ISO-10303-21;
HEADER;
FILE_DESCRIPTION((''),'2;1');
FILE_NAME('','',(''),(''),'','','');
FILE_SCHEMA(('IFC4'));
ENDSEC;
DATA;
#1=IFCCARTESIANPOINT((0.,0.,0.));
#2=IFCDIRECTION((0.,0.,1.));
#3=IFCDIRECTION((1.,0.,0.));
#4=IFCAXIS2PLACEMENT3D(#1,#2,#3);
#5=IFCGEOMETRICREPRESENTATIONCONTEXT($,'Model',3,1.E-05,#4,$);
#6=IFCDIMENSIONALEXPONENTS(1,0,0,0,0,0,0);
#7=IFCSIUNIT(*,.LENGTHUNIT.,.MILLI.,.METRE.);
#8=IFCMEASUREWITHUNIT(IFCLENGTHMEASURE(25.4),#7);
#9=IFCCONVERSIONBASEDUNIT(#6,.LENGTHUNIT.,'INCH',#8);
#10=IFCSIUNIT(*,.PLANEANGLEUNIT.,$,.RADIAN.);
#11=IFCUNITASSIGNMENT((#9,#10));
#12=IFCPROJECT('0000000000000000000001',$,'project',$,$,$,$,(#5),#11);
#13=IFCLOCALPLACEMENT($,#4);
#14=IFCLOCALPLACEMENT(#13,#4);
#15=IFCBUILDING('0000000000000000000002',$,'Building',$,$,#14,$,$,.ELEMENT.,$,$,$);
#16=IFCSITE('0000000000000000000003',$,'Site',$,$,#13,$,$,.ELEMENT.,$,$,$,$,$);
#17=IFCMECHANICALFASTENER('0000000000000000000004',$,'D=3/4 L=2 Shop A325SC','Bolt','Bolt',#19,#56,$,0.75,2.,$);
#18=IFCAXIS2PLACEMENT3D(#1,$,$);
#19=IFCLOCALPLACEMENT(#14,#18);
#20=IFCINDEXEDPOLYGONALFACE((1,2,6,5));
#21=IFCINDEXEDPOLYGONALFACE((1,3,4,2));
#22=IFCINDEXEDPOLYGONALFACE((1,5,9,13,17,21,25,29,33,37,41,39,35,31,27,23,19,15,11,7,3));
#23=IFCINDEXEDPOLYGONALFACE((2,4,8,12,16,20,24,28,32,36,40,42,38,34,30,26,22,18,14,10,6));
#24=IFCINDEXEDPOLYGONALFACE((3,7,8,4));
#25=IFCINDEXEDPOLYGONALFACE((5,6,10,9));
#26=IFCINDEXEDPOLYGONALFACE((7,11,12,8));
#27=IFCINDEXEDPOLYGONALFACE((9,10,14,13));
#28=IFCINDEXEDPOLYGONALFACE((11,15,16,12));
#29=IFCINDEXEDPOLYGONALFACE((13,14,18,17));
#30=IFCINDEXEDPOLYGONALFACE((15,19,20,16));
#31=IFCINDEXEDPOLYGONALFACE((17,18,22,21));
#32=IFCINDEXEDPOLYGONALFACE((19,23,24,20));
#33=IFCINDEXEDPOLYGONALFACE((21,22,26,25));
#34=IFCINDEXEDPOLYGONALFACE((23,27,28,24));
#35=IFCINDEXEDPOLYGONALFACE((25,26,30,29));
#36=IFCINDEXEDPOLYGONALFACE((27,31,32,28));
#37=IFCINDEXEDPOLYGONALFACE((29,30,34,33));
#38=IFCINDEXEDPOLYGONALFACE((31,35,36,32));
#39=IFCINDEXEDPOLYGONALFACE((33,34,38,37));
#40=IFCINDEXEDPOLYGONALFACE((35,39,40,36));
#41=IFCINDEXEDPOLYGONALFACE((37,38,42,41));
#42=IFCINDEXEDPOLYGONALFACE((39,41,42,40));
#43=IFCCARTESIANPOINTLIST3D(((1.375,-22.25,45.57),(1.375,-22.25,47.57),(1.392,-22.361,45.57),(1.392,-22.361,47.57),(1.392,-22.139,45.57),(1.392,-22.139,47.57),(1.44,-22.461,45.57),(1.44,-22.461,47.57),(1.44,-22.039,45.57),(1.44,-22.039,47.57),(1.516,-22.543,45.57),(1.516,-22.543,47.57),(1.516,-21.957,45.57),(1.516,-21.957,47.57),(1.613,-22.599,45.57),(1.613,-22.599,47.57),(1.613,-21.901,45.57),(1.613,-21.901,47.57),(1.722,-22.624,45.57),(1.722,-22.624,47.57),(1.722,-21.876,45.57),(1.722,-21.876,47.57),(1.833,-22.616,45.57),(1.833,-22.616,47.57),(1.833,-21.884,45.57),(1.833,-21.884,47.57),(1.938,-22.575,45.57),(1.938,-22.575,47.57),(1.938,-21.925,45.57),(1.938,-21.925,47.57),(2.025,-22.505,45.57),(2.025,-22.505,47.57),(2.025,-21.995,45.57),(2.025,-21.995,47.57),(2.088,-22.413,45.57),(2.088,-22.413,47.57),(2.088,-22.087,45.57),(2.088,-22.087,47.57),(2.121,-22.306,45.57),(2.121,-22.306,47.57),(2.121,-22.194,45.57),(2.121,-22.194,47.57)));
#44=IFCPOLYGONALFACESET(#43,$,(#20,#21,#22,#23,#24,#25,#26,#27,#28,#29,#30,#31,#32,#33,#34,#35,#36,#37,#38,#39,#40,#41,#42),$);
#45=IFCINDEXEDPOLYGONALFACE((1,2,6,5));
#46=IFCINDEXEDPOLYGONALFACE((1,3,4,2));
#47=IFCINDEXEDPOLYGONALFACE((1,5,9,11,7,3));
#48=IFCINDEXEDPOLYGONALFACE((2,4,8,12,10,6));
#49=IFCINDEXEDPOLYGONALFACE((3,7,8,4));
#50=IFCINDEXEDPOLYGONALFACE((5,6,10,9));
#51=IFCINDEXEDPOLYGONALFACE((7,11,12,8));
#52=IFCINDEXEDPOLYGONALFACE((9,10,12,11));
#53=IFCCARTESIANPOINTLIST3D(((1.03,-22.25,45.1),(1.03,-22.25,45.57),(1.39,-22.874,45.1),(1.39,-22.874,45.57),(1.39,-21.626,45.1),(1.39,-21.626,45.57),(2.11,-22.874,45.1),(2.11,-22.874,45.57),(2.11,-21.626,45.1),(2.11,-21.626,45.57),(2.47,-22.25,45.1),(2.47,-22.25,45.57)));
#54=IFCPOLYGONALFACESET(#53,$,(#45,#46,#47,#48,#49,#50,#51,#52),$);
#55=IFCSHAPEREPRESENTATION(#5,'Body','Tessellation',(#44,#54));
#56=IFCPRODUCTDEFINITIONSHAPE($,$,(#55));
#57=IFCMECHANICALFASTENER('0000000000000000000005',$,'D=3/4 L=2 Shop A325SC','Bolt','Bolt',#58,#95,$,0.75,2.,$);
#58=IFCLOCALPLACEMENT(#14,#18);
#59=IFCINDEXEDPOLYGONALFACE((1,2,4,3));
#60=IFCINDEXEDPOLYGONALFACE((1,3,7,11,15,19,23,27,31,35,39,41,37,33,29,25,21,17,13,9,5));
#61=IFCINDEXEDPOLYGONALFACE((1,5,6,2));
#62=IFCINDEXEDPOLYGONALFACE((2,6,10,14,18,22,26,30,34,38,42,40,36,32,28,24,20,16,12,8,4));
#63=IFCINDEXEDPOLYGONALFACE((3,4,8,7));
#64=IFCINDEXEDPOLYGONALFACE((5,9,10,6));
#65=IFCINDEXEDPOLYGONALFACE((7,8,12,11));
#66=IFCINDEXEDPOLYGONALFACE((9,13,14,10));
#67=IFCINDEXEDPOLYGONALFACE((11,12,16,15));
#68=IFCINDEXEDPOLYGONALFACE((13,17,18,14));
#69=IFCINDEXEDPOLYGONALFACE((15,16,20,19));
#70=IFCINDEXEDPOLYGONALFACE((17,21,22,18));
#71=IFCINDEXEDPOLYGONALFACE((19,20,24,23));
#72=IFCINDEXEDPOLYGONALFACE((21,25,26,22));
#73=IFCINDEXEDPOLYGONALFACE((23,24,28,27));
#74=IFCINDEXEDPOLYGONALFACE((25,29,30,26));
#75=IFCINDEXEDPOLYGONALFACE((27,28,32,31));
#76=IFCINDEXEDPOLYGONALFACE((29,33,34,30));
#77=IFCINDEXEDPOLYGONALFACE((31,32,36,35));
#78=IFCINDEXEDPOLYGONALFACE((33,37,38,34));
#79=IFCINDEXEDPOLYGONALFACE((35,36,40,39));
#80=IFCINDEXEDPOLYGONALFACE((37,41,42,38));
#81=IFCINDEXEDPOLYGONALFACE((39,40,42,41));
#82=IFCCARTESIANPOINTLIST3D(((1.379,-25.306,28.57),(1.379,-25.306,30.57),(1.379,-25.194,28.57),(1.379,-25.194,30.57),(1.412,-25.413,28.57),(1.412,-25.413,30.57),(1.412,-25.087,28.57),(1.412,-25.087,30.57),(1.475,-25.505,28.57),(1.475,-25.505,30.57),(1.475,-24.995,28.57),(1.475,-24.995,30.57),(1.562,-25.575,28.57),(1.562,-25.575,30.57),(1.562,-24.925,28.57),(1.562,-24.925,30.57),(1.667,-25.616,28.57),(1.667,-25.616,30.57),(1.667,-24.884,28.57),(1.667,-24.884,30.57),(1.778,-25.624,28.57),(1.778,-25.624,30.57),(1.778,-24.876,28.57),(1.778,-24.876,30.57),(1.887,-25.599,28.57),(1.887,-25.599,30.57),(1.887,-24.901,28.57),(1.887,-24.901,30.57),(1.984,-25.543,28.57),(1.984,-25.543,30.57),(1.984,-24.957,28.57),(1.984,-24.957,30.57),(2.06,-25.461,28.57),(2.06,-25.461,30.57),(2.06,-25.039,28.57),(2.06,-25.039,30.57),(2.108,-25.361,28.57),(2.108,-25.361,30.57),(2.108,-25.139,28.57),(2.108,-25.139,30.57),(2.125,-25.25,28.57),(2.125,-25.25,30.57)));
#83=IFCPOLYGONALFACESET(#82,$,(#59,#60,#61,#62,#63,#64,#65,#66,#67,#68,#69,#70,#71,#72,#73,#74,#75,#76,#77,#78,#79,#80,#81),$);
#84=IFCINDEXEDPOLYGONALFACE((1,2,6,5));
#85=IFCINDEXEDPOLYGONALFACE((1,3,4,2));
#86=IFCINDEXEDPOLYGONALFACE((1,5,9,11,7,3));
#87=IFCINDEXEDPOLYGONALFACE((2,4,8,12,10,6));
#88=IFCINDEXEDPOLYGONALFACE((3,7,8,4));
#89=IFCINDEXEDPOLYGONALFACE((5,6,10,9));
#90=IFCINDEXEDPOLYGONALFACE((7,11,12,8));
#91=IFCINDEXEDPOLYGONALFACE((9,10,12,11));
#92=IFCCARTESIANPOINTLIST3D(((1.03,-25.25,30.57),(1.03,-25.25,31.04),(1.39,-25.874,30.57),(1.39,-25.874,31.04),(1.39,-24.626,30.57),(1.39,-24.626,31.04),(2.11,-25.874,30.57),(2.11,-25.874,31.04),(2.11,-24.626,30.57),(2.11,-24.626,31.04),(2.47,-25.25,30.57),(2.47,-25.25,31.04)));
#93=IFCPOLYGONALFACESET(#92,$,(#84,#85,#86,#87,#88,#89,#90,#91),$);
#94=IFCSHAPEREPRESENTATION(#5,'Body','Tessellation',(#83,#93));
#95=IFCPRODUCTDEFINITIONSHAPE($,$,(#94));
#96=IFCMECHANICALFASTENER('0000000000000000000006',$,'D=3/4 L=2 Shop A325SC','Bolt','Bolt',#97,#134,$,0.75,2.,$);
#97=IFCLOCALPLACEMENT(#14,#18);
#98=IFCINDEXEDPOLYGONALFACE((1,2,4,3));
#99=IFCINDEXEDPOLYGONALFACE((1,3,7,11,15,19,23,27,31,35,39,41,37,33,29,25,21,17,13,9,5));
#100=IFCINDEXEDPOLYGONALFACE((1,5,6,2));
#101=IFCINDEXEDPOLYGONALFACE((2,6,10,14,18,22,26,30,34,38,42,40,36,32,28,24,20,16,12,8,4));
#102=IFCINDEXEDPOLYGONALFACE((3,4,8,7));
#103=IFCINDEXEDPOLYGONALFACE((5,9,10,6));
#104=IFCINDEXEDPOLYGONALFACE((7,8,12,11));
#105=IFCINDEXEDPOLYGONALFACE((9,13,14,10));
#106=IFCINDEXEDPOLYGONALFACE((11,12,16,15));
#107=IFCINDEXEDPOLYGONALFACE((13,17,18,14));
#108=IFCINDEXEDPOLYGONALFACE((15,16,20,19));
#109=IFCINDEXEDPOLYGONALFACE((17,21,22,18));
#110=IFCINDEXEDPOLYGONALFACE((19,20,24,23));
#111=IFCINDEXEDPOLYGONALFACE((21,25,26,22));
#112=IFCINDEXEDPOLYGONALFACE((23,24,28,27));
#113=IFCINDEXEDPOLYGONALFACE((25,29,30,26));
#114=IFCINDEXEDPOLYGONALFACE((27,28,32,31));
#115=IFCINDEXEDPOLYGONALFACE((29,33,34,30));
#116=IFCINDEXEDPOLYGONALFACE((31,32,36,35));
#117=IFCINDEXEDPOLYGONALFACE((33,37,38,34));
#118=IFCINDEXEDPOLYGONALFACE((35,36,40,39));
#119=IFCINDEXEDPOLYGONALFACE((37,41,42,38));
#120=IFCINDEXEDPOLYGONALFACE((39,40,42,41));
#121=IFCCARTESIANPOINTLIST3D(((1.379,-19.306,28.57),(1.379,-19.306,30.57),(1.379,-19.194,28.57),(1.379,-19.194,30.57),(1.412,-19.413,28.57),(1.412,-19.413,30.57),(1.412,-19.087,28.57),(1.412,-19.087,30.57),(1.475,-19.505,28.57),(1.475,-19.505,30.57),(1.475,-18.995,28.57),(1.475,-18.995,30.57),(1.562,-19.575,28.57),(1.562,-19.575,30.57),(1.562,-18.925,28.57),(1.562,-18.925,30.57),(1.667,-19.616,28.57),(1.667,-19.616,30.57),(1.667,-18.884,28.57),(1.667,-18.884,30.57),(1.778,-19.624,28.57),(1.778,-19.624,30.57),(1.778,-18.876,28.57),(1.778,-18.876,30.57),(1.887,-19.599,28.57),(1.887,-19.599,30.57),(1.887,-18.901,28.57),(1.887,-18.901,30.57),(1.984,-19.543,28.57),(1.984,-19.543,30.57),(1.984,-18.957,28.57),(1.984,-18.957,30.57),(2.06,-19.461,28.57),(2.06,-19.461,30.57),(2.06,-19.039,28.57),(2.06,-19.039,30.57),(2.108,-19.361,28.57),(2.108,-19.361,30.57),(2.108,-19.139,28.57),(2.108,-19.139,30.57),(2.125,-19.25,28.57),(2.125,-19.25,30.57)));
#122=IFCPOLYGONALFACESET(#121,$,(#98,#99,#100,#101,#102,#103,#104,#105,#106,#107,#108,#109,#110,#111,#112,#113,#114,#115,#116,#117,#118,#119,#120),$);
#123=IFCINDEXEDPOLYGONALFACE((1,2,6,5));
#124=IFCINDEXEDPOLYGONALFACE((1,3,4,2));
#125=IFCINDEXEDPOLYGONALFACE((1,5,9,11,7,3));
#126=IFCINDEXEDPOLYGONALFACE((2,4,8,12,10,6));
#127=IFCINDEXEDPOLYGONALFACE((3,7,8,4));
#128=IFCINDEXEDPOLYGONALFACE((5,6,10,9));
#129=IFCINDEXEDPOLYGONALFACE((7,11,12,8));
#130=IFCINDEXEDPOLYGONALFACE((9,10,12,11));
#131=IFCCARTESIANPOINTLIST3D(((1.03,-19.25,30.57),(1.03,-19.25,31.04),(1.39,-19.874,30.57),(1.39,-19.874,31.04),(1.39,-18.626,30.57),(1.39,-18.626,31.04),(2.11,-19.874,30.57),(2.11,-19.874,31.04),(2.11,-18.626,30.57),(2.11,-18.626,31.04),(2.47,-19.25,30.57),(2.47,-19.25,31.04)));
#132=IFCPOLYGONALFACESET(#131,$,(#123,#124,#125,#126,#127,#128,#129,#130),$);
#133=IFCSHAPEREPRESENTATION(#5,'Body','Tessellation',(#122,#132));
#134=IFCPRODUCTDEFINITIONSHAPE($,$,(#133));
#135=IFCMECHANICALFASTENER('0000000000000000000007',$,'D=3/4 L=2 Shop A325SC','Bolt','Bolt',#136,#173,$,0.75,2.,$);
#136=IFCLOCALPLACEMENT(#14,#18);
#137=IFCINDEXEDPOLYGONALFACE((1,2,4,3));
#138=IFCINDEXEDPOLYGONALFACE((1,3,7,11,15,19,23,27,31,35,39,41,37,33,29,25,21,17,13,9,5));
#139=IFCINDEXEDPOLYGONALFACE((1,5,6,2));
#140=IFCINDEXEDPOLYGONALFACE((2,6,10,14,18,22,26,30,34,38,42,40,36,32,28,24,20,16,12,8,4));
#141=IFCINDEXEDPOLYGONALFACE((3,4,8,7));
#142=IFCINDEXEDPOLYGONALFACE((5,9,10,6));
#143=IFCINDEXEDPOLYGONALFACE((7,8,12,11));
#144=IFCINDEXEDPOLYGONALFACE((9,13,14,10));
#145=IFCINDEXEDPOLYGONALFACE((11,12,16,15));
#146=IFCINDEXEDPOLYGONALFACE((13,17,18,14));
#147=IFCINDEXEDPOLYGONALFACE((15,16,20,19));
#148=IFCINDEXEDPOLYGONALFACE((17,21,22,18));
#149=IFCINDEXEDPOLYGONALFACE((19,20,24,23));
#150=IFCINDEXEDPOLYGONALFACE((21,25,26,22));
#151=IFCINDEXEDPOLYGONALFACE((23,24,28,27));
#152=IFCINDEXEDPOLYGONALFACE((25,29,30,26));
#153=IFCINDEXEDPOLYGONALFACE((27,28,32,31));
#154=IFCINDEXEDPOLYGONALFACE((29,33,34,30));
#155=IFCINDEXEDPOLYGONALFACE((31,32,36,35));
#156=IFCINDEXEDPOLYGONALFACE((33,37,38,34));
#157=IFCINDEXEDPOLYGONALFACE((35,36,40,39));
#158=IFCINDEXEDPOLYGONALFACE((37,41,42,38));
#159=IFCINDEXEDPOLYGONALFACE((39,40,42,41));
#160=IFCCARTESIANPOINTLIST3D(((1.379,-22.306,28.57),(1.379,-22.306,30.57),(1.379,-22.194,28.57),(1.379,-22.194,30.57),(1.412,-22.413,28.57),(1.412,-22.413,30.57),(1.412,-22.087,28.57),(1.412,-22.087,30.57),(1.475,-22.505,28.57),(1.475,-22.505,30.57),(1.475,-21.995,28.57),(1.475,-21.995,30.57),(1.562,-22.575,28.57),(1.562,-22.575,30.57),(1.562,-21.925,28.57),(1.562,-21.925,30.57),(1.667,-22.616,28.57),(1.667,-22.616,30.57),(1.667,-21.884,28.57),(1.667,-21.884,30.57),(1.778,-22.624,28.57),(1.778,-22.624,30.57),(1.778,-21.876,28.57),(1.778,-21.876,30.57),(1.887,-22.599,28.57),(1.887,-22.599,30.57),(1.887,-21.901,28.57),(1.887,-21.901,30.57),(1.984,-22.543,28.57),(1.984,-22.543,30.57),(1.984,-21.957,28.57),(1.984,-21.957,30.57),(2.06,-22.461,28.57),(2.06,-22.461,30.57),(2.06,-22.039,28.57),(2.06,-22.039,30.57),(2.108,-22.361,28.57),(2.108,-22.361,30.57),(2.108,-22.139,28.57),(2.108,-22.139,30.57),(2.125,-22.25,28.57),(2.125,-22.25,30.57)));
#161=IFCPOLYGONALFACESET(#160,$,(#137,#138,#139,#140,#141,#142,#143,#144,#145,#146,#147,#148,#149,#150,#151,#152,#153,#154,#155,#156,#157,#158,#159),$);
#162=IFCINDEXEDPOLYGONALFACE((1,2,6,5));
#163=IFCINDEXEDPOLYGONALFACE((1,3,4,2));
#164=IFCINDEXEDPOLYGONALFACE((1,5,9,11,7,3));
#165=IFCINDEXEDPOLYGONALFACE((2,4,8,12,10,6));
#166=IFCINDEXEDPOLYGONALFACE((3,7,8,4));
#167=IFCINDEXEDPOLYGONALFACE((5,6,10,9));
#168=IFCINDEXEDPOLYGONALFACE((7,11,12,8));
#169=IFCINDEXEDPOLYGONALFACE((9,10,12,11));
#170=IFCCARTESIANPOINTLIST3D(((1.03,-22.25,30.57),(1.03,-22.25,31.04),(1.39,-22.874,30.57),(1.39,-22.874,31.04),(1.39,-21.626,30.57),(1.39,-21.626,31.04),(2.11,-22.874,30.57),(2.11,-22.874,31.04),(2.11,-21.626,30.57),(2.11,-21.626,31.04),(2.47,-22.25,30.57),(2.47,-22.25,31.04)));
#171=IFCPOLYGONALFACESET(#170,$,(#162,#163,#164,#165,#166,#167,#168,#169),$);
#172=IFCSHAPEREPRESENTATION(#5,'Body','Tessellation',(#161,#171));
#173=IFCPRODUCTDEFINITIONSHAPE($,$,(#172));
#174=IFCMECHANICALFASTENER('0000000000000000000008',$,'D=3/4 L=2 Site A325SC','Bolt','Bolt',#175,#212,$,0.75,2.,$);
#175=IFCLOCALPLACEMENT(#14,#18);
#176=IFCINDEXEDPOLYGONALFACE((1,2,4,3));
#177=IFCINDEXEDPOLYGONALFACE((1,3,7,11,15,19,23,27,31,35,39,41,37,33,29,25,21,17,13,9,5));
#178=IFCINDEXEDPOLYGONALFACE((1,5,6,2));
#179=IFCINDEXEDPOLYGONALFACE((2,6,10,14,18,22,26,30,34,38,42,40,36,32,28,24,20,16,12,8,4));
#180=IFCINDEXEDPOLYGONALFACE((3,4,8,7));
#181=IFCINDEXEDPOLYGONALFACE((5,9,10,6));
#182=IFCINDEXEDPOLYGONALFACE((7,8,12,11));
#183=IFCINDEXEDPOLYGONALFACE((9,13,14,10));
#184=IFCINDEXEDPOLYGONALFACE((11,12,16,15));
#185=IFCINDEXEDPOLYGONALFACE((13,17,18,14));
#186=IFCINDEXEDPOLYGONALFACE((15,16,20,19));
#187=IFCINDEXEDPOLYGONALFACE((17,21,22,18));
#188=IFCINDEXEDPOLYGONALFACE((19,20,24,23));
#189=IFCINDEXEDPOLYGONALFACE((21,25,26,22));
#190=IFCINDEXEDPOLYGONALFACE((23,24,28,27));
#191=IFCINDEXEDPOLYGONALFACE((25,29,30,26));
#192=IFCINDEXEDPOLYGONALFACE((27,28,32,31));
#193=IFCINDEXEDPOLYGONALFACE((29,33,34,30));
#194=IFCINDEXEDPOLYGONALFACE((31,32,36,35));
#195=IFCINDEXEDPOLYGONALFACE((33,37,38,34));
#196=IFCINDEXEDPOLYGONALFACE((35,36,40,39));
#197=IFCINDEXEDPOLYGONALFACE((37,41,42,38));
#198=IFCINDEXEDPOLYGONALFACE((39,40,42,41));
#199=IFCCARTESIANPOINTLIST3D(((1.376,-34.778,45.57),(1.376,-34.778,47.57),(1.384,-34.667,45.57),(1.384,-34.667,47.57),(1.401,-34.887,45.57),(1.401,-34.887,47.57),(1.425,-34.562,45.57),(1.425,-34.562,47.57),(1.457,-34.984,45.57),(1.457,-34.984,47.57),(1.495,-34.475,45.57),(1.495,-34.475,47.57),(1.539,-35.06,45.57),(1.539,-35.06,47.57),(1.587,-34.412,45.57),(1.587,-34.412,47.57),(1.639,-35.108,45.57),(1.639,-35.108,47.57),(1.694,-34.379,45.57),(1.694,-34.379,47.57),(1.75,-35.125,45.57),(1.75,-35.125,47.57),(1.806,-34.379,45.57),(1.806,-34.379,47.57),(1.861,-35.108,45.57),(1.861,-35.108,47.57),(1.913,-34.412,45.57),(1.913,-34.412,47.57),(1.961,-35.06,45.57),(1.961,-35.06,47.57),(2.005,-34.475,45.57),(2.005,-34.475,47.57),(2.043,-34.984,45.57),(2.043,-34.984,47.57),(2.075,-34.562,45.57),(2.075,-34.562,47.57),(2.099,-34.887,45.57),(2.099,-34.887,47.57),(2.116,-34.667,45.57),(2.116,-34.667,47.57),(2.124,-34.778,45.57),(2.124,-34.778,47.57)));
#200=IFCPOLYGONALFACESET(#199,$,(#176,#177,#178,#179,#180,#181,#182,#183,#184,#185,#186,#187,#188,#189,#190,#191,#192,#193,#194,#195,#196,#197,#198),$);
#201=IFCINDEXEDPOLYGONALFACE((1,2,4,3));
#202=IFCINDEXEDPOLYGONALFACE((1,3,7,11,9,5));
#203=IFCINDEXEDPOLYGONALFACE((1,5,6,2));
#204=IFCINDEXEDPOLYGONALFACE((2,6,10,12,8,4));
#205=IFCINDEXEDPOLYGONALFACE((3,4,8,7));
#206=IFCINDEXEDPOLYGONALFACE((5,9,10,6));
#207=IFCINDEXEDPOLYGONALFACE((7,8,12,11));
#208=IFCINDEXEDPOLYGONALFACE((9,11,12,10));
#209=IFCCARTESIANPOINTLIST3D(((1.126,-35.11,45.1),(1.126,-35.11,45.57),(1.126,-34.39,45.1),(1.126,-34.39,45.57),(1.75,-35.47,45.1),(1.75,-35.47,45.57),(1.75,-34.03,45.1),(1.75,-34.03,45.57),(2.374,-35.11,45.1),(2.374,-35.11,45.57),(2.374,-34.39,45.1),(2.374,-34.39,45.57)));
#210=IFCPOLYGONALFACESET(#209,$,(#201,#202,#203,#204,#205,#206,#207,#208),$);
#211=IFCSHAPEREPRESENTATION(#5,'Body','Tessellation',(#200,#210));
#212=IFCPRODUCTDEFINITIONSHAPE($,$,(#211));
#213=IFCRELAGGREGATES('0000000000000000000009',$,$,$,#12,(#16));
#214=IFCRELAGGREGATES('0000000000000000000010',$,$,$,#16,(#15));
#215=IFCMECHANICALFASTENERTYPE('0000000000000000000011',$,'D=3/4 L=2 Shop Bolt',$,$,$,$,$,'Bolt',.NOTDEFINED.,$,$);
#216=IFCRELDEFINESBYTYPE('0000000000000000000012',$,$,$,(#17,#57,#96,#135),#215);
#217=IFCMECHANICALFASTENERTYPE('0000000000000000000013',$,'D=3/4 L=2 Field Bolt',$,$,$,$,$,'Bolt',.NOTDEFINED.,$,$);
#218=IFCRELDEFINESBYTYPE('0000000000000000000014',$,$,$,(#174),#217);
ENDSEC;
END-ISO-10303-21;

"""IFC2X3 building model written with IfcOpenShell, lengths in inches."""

from ifc_helpers import new_model, entity, si_unit, converted_unit, frame, origin_with_axes, origin_2d_with_axis, place, context, project, spatial, polyline, circle, outline, extrude, source, transform, mapped, type_object, type_shapes, element, save


model = new_model("IFC2X3")

# Units and contexts
model_context = context("Model", 3, precision=1e-05, world=origin_with_axes())
ifc_project = project(units=[converted_unit("LENGTHUNIT", "INCH", entity("IfcLengthMeasure", 25.4), si_unit("LENGTHUNIT", "METRE", prefix="MILLI"), dimensions=[1, 0, 0, 0, 0, 0, 0]), si_unit("PLANEANGLEUNIT", "RADIAN")], contexts=[model_context])

# Site, building
site_placement = place(None, origin_with_axes())
site = spatial("IfcSite", under=ifc_project, at=site_placement, Name="Site", CompositionType="ELEMENT")
building_placement = place(site_placement, origin_with_axes())
building = spatial("IfcBuilding", under=site, at=building_placement, Name="Building", CompositionType="ELEMENT")

# Mechanical fasteners
mechanical_fastener_type_1 = type_object("IfcMechanicalFastenerType", Name="D=3/4 L=2 Shop Bolt", ElementType="Bolt")
shared_shape_1 = source(origin_with_axes(), model_context, "Body", "SweptSolid", [
    extrude(circle(Radius=0.375, at=origin_2d_with_axis()), frame((0.0, 0.0, 0.0), z_axis=(1.0, 0.0, 0.0), x_axis=(0.0, 1.0, 0.0)), (0.0, 0.0, 1.0), 2.0),
    extrude(outline(polyline([(-0.72, 0.0), (-0.36, 0.624), (0.36, 0.624), (0.72, 0.0), (0.36, -0.624), (-0.36, -0.624), (-0.72, 0.0)])), frame((0.0, 0.0, 0.0), z_axis=(1.0, 0.0, 0.0), x_axis=(0.0, 1.0, 0.0)), (0.0, 0.0, -1.0), 0.47),
])
type_shapes(mechanical_fastener_type_1, [shared_shape_1])
placement_1 = place(building_placement, frame((0.0, 0.0, 46.0), z_axis=(0.0, 0.0, 1.0), x_axis=(0.0, -1.0, 0.0)))
placement_2 = place(placement_1, frame((25.25, -1.75, -0.43), z_axis=(1.0, 0.0, 0.0), x_axis=(0.0, 0.0, 1.0)))
for number, where, z_axis, x_axis, name in (
    (1, (0.0, -3.5, -3.0), (0.0, 0.0, 1.0), (1.0, 0.0, 0.0), "D=3/4 L=2 Shop A325SC"),
):
    element("IfcMechanicalFastener", number, at=place(placement_2, frame(where, z_axis=z_axis, x_axis=x_axis)), type_object=mechanical_fastener_type_1, Name=name, Description="Bolt", ObjectType="Bolt", NominalDiameter=0.75, NominalLength=2.0, context=model_context, shape_type="MappedRepresentation", body=[
        mapped(shared_shape_1, transform((0.0, 0.0, 0.0), scale=1.0)),
    ])
placement_3 = place(placement_1, frame((25.25, -1.75, -15.43), z_axis=(1.0, 0.0, 0.0), x_axis=(0.0, 0.0, -1.0)))
for number, where, z_axis, x_axis, name in (
    (2, (0.0, 3.5, 0.0), (0.0, 0.0, 1.0), (1.0, 0.0, 0.0), "D=3/4 L=2 Shop A325SC"),
    (3, (0.0, 3.5, -6.0), (0.0, 0.0, 1.0), (1.0, 0.0, 0.0), "D=3/4 L=2 Shop A325SC"),
    (4, (0.0, 3.5, -3.0), (0.0, 0.0, 1.0), (1.0, 0.0, 0.0), "D=3/4 L=2 Shop A325SC"),
):
    element("IfcMechanicalFastener", number, at=place(placement_3, frame(where, z_axis=z_axis, x_axis=x_axis)), type_object=mechanical_fastener_type_1, Name=name, Description="Bolt", ObjectType="Bolt", NominalDiameter=0.75, NominalLength=2.0, context=model_context, shape_type="MappedRepresentation", body=[
        mapped(shared_shape_1, transform((0.0, 0.0, 0.0), scale=1.0)),
    ])
mechanical_fastener_type_2 = type_object("IfcMechanicalFastenerType", Name="D=3/4 L=2 Field Bolt", ElementType="Bolt")
shared_shape_2 = source(origin_with_axes(), model_context, "Body", "SweptSolid", [
    extrude(circle(Radius=0.375, at=origin_2d_with_axis()), frame((0.0, 0.0, 0.0), z_axis=(1.0, 0.0, 0.0), x_axis=(0.0, 1.0, 0.0)), (0.0, 0.0, 1.0), 2.0),
    extrude(outline(polyline([(-0.72, 0.0), (-0.36, 0.624), (0.36, 0.624), (0.72, 0.0), (0.36, -0.624), (-0.36, -0.624), (-0.72, 0.0)])), frame((0.0, 0.0, 0.0), z_axis=(1.0, 0.0, 0.0), x_axis=(0.0, 1.0, 0.0)), (0.0, 0.0, -1.0), 0.47),
])
type_shapes(mechanical_fastener_type_2, [shared_shape_2])
placement_4 = place(placement_1, frame((28.75, -1.75, -0.43), z_axis=(0.0, 1.0, 0.0), x_axis=(0.0, 0.0, 1.0)))
for number, where, z_axis, x_axis, name in (
    (5, (0.0, 6.0, 3.5), (0.0, 0.0, 1.0), (1.0, 0.0, 0.0), "D=3/4 L=2 Site A325SC"),
):
    element("IfcMechanicalFastener", number, at=place(placement_4, frame(where, z_axis=z_axis, x_axis=x_axis)), type_object=mechanical_fastener_type_2, Name=name, Description="Bolt", ObjectType="Bolt", NominalDiameter=0.75, NominalLength=2.0, context=model_context, shape_type="MappedRepresentation", body=[
        mapped(shared_shape_2, transform((0.0, 0.0, 0.0), scale=1.0)),
    ])

save(model, "model.ifc")
